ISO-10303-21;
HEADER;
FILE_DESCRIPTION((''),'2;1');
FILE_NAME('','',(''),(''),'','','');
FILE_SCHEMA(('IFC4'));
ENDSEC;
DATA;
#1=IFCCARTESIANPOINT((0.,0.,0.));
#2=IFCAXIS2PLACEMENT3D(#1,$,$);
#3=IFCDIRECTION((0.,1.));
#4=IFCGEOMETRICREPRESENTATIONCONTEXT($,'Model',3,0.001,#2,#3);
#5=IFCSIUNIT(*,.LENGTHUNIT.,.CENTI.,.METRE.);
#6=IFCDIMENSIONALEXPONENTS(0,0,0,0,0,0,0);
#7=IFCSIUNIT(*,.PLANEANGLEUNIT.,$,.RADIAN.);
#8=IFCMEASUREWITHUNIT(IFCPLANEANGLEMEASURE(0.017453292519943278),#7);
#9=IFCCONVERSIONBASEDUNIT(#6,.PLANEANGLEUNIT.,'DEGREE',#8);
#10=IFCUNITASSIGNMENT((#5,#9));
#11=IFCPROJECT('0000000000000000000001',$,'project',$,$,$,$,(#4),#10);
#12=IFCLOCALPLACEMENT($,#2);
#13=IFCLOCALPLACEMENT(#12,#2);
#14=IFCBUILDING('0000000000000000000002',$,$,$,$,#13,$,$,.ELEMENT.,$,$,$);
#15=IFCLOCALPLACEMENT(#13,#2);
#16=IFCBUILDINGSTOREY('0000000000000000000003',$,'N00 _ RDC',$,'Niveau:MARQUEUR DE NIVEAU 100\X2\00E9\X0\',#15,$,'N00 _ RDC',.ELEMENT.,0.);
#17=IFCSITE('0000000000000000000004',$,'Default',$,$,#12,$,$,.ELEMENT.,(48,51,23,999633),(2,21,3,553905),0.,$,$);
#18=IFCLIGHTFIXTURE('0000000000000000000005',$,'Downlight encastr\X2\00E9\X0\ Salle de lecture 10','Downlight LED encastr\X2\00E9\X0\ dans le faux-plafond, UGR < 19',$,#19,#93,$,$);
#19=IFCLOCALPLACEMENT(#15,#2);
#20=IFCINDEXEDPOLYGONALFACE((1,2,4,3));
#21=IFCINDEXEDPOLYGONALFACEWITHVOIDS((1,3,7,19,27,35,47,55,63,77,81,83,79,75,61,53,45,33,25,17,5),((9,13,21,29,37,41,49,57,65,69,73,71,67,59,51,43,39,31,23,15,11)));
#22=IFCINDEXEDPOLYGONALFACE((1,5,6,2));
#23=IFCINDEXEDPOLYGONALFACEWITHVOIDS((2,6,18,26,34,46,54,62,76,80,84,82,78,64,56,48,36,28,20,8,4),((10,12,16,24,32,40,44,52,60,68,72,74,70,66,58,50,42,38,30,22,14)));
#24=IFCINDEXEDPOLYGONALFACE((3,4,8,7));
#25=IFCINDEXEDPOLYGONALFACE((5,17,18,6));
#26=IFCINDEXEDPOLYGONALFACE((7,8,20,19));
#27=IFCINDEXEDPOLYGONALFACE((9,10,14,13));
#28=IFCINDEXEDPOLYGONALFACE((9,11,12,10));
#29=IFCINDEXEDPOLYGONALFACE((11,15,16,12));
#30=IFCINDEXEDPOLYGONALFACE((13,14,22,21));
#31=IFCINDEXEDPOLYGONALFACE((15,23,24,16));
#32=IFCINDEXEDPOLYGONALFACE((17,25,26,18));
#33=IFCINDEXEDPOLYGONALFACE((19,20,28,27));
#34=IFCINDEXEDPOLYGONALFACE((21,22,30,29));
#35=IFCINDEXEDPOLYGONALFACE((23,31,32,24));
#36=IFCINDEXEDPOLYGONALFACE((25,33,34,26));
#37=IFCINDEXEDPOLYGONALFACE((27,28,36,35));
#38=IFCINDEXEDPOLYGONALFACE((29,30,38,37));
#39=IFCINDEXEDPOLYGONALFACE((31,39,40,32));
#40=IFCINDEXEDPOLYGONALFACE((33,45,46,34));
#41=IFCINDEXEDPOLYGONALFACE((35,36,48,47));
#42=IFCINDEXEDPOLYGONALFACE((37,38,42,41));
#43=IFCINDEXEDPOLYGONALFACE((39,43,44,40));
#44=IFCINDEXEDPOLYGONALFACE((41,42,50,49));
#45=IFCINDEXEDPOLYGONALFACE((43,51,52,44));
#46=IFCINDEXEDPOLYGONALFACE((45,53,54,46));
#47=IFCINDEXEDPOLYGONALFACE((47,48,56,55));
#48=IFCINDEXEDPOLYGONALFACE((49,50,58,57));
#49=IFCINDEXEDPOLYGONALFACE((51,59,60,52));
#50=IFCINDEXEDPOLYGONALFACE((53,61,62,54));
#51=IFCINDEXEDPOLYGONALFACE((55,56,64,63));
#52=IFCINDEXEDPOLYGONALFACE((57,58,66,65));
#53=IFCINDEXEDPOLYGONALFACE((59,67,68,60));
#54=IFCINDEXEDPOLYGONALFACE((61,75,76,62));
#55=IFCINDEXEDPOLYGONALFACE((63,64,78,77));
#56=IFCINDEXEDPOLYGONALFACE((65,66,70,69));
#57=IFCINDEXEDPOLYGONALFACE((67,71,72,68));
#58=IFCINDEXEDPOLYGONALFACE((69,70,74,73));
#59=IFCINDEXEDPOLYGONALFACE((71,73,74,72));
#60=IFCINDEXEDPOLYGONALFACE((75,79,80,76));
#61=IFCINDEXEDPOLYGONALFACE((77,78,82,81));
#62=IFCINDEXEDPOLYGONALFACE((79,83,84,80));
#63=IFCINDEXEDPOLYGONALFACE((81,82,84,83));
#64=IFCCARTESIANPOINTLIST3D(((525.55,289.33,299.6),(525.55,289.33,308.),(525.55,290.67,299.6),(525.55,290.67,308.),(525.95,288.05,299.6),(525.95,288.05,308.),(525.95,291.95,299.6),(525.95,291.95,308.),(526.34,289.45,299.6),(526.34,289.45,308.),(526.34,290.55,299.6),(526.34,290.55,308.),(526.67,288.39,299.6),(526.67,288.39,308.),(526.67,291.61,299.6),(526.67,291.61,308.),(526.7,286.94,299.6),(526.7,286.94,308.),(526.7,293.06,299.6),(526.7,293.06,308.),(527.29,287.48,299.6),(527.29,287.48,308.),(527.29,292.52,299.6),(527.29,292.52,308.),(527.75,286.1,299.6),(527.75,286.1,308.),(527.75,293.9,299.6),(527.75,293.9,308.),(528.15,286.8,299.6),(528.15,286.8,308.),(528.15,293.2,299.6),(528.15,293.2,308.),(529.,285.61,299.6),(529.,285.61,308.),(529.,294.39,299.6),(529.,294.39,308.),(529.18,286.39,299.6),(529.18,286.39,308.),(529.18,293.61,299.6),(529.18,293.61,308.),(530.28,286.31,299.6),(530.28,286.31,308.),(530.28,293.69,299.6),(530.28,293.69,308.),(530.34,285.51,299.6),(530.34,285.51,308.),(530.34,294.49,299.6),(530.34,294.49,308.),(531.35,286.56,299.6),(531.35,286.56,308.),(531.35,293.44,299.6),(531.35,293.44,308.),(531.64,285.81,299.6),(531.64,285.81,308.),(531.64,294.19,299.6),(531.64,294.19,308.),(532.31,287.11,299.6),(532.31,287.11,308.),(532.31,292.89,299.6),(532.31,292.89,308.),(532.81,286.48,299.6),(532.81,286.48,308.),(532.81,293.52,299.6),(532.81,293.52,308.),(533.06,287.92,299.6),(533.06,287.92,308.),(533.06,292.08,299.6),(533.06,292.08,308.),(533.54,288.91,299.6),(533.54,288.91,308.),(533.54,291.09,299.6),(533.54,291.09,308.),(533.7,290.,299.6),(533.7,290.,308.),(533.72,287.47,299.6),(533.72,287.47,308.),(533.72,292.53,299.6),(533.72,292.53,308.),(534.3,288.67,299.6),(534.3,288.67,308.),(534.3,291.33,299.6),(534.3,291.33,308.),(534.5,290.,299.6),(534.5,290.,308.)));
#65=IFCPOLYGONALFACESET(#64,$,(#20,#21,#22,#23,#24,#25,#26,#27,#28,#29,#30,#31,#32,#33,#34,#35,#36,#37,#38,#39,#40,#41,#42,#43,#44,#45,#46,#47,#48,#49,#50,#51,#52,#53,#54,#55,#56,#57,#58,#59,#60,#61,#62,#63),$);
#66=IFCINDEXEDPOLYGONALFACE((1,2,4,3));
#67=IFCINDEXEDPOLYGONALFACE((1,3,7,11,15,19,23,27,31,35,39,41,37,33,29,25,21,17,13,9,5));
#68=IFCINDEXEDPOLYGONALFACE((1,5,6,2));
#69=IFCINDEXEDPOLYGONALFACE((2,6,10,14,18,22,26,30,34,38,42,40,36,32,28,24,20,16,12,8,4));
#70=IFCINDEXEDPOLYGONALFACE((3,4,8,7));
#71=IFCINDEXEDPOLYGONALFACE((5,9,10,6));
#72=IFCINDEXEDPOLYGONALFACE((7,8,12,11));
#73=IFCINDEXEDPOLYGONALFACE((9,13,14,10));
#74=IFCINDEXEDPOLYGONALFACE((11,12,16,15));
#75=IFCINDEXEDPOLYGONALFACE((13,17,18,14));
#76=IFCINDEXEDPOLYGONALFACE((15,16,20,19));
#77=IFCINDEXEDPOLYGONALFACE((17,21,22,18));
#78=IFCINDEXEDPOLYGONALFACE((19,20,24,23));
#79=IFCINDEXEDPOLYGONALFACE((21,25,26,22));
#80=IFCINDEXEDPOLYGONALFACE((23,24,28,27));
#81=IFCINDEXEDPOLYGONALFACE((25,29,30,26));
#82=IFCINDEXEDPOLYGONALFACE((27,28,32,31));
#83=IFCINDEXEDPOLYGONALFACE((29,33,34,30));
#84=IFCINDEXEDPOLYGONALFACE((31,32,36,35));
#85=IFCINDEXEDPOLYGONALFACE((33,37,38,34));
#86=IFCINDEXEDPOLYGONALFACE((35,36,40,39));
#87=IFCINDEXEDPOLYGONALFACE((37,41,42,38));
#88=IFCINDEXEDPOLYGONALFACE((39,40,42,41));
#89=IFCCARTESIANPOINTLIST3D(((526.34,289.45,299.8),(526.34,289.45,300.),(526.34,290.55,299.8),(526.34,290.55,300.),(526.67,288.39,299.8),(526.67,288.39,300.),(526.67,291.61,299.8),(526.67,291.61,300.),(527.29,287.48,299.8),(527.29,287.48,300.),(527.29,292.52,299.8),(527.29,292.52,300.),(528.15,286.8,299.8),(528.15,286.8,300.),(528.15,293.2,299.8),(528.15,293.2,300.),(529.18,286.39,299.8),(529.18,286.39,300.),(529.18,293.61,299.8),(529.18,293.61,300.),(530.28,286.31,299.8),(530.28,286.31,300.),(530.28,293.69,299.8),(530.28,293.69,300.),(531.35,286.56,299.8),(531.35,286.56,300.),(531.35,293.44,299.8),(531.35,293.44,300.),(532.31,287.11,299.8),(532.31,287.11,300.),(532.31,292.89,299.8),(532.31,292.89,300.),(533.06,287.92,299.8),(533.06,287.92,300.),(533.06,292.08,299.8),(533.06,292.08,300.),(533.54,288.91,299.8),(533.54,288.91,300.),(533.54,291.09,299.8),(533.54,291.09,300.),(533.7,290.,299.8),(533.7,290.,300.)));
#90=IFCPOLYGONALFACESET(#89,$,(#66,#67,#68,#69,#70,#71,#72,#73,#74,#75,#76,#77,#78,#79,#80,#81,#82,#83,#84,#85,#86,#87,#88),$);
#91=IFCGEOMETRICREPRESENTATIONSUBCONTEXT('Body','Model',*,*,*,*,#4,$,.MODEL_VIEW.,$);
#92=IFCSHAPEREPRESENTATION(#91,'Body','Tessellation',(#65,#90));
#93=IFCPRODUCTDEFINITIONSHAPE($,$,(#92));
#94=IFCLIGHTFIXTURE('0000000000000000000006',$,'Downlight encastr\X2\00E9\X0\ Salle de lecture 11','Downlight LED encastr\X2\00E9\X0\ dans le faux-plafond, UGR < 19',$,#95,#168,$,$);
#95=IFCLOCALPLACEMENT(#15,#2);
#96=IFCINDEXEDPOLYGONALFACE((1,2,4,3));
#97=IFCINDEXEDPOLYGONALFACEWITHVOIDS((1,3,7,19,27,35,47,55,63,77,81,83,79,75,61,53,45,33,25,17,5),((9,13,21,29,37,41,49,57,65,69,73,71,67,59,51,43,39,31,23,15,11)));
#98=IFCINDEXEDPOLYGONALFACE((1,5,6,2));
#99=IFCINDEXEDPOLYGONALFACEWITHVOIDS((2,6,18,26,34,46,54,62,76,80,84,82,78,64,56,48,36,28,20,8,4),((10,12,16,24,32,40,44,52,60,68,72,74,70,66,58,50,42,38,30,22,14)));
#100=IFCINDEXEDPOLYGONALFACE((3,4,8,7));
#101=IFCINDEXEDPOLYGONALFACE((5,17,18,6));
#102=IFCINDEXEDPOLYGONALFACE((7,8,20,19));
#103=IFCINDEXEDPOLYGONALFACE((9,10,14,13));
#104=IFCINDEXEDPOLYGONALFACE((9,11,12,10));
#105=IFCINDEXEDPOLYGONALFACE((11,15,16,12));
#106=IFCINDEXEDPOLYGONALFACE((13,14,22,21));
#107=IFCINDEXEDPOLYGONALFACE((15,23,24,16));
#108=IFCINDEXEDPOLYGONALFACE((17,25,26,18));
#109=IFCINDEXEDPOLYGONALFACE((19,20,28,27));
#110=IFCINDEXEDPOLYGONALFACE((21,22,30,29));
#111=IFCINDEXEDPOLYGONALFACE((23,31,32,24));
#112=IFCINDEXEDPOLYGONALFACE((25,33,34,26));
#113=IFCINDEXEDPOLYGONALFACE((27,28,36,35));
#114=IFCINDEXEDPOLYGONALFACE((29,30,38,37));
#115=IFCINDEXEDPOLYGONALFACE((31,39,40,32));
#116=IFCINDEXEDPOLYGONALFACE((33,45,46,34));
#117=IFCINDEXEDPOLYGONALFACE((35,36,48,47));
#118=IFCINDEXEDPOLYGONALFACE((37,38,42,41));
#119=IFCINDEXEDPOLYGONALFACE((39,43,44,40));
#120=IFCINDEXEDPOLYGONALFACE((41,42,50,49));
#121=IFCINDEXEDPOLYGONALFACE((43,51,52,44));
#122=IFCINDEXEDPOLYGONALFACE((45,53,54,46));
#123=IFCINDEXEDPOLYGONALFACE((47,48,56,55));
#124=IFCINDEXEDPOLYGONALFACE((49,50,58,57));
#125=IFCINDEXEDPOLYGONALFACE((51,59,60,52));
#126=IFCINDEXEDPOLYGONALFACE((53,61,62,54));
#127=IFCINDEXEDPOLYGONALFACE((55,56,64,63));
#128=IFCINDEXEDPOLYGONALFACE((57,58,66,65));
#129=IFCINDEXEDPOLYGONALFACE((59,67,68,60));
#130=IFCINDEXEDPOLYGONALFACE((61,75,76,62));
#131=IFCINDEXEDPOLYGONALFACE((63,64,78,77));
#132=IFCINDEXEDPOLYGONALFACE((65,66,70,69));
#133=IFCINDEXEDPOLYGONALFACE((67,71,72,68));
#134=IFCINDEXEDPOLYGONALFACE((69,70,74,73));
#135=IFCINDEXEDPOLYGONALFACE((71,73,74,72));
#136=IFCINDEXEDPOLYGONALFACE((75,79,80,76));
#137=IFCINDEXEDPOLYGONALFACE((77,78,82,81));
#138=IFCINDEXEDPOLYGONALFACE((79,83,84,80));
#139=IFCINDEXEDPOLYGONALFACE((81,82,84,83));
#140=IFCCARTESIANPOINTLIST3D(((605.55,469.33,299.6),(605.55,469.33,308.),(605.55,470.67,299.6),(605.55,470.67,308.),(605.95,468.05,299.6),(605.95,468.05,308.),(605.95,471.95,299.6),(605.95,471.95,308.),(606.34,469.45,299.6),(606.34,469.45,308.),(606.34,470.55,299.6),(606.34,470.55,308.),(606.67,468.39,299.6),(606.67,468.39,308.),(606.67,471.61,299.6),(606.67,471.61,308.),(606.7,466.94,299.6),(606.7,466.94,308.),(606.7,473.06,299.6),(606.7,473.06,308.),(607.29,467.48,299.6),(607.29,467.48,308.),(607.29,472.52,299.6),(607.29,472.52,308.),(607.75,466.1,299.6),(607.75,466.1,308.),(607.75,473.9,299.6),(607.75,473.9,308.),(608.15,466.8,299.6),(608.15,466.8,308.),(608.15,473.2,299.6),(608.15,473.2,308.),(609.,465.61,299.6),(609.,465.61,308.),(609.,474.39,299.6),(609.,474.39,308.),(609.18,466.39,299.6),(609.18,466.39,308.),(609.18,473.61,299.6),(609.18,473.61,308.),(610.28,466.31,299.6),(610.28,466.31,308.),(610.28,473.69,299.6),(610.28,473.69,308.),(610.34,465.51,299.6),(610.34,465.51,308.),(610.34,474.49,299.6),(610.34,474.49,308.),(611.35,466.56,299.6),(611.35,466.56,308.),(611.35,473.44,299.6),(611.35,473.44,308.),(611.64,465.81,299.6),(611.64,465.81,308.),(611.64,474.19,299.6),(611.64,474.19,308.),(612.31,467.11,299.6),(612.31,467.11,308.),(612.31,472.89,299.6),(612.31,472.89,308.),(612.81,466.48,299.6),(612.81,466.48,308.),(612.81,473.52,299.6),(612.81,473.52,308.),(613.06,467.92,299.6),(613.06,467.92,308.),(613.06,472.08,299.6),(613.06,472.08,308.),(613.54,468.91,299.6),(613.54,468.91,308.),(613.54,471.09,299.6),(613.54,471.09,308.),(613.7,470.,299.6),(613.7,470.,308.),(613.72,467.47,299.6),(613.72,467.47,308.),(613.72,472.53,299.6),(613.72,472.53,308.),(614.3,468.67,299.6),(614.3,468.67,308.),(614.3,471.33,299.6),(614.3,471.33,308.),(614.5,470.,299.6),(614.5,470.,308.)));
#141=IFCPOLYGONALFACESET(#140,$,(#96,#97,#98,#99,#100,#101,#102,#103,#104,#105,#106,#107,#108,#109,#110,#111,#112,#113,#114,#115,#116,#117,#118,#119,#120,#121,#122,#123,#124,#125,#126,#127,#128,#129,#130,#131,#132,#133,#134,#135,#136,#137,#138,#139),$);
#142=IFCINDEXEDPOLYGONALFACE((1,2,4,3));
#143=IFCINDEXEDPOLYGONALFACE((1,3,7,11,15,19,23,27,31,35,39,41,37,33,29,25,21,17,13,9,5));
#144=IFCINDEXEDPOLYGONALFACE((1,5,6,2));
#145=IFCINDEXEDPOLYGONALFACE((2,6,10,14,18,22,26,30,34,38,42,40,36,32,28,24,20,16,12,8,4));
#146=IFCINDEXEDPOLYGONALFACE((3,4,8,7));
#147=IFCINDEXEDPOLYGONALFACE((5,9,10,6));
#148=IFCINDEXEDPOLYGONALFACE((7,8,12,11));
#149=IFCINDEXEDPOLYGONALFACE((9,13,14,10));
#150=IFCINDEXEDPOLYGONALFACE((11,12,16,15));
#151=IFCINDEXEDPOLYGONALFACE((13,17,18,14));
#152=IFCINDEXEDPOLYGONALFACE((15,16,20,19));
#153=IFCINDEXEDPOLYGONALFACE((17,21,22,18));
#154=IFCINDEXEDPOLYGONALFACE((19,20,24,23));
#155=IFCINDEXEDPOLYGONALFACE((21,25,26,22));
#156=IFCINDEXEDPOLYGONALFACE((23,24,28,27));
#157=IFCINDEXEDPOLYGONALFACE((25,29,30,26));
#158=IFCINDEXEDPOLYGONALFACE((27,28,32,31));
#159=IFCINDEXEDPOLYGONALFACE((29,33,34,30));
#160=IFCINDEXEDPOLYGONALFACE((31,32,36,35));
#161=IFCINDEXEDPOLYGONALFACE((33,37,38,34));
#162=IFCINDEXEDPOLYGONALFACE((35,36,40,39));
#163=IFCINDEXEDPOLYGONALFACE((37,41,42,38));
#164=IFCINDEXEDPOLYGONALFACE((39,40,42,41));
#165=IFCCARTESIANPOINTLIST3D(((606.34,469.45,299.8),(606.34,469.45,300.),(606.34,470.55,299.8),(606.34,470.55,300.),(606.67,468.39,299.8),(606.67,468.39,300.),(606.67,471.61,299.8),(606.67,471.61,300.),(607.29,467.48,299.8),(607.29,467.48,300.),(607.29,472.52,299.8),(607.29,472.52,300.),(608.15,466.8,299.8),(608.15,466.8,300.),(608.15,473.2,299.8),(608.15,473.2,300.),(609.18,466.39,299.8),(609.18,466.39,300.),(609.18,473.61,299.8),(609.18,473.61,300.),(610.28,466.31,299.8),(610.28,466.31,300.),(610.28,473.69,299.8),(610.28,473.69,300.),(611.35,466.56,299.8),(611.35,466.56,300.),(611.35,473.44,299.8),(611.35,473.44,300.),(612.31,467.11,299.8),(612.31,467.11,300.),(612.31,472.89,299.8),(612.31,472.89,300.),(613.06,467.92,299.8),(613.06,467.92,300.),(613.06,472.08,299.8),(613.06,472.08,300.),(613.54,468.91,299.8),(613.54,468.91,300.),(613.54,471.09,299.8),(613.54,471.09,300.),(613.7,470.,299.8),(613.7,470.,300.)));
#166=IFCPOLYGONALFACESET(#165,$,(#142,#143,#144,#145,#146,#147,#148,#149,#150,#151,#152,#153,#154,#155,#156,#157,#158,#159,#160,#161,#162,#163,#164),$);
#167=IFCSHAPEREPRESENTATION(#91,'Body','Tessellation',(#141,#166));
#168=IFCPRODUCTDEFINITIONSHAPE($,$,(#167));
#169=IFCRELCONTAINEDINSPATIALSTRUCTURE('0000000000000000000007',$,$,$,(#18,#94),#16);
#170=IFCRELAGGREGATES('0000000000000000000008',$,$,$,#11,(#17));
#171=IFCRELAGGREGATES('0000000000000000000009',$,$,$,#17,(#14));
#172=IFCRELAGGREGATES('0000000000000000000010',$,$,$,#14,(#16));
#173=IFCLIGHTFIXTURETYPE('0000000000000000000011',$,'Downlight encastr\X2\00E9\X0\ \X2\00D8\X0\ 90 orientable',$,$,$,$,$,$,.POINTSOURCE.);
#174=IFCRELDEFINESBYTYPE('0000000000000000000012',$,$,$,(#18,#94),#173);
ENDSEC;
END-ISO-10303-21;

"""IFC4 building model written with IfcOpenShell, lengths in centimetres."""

from ifc_helpers import new_model, entity, si_unit, converted_unit, direction, frame, frame_2d, origin, origin_with_axes, place, context, subcontext, project, spatial, circle, hollow_circle, extrude, type_object, element, save


model = new_model("IFC4")

# Units and contexts
model_context = context("Model", 3, precision=0.001, world=origin(), true_north=direction((0.0, 1.0)))
body_context = subcontext(model_context, "Body", "Model", "MODEL_VIEW")
ifc_project = project(units=[si_unit("LENGTHUNIT", "METRE", prefix="CENTI"), converted_unit("PLANEANGLEUNIT", "DEGREE", entity("IfcPlaneAngleMeasure", 0.017453292519943278), si_unit("PLANEANGLEUNIT", "RADIAN"), dimensions=[0, 0, 0, 0, 0, 0, 0])], contexts=[model_context])

# Site, building, storey
site_placement = place(None, origin())
site = spatial("IfcSite", under=ifc_project, at=site_placement, Name="Default", CompositionType="ELEMENT", RefLatitude=(48, 51, 23, 999633), RefLongitude=(2, 21, 3, 553905), RefElevation=0.0)
building_placement = place(site_placement, origin())
building = spatial("IfcBuilding", under=site, at=building_placement, CompositionType="ELEMENT")
storey_placement = place(building_placement, origin())
storey = spatial("IfcBuildingStorey", under=building, at=storey_placement, Name="N00 _ RDC", ObjectType="Niveau:MARQUEUR DE NIVEAU 100é", LongName="N00 _ RDC", CompositionType="ELEMENT", Elevation=0.0)

# Light fixtures
light_fixture_type_1 = type_object("IfcLightFixtureType", Name="Downlight encastré Ø 90 orientable", PredefinedType="POINTSOURCE")
light_fixture_1_placement = place(storey_placement, origin_with_axes())
element("IfcLightFixture", 1, at=light_fixture_1_placement, inside=storey, type_object=light_fixture_type_1, Name="Downlight encastré Salle de lecture 10", Description="Downlight LED encastré dans le faux-plafond, UGR < 19", context=body_context, shape_type="SweptSolid", body=[
    extrude(hollow_circle(Radius=4.5, WallThickness=0.8, at=frame_2d((530.0, 290.0))), frame((0.0, 0.0, 299.6)), (0.0, 0.0, 1.0), 8.4),
    extrude(circle(Radius=3.7, at=frame_2d((530.0, 290.0))), frame((0.0, 0.0, 299.8)), (0.0, 0.0, 1.0), 0.2),
])
light_fixture_2_placement = place(storey_placement, origin_with_axes())
element("IfcLightFixture", 2, at=light_fixture_2_placement, inside=storey, type_object=light_fixture_type_1, Name="Downlight encastré Salle de lecture 11", Description="Downlight LED encastré dans le faux-plafond, UGR < 19", context=body_context, shape_type="SweptSolid", body=[
    extrude(hollow_circle(Radius=4.5, WallThickness=0.8, at=frame_2d((610.0, 470.0))), frame((0.0, 0.0, 299.6)), (0.0, 0.0, 1.0), 8.4),
    extrude(circle(Radius=3.7, at=frame_2d((610.0, 470.0))), frame((0.0, 0.0, 299.8)), (0.0, 0.0, 1.0), 0.2),
])

save(model, "model.ifc")
